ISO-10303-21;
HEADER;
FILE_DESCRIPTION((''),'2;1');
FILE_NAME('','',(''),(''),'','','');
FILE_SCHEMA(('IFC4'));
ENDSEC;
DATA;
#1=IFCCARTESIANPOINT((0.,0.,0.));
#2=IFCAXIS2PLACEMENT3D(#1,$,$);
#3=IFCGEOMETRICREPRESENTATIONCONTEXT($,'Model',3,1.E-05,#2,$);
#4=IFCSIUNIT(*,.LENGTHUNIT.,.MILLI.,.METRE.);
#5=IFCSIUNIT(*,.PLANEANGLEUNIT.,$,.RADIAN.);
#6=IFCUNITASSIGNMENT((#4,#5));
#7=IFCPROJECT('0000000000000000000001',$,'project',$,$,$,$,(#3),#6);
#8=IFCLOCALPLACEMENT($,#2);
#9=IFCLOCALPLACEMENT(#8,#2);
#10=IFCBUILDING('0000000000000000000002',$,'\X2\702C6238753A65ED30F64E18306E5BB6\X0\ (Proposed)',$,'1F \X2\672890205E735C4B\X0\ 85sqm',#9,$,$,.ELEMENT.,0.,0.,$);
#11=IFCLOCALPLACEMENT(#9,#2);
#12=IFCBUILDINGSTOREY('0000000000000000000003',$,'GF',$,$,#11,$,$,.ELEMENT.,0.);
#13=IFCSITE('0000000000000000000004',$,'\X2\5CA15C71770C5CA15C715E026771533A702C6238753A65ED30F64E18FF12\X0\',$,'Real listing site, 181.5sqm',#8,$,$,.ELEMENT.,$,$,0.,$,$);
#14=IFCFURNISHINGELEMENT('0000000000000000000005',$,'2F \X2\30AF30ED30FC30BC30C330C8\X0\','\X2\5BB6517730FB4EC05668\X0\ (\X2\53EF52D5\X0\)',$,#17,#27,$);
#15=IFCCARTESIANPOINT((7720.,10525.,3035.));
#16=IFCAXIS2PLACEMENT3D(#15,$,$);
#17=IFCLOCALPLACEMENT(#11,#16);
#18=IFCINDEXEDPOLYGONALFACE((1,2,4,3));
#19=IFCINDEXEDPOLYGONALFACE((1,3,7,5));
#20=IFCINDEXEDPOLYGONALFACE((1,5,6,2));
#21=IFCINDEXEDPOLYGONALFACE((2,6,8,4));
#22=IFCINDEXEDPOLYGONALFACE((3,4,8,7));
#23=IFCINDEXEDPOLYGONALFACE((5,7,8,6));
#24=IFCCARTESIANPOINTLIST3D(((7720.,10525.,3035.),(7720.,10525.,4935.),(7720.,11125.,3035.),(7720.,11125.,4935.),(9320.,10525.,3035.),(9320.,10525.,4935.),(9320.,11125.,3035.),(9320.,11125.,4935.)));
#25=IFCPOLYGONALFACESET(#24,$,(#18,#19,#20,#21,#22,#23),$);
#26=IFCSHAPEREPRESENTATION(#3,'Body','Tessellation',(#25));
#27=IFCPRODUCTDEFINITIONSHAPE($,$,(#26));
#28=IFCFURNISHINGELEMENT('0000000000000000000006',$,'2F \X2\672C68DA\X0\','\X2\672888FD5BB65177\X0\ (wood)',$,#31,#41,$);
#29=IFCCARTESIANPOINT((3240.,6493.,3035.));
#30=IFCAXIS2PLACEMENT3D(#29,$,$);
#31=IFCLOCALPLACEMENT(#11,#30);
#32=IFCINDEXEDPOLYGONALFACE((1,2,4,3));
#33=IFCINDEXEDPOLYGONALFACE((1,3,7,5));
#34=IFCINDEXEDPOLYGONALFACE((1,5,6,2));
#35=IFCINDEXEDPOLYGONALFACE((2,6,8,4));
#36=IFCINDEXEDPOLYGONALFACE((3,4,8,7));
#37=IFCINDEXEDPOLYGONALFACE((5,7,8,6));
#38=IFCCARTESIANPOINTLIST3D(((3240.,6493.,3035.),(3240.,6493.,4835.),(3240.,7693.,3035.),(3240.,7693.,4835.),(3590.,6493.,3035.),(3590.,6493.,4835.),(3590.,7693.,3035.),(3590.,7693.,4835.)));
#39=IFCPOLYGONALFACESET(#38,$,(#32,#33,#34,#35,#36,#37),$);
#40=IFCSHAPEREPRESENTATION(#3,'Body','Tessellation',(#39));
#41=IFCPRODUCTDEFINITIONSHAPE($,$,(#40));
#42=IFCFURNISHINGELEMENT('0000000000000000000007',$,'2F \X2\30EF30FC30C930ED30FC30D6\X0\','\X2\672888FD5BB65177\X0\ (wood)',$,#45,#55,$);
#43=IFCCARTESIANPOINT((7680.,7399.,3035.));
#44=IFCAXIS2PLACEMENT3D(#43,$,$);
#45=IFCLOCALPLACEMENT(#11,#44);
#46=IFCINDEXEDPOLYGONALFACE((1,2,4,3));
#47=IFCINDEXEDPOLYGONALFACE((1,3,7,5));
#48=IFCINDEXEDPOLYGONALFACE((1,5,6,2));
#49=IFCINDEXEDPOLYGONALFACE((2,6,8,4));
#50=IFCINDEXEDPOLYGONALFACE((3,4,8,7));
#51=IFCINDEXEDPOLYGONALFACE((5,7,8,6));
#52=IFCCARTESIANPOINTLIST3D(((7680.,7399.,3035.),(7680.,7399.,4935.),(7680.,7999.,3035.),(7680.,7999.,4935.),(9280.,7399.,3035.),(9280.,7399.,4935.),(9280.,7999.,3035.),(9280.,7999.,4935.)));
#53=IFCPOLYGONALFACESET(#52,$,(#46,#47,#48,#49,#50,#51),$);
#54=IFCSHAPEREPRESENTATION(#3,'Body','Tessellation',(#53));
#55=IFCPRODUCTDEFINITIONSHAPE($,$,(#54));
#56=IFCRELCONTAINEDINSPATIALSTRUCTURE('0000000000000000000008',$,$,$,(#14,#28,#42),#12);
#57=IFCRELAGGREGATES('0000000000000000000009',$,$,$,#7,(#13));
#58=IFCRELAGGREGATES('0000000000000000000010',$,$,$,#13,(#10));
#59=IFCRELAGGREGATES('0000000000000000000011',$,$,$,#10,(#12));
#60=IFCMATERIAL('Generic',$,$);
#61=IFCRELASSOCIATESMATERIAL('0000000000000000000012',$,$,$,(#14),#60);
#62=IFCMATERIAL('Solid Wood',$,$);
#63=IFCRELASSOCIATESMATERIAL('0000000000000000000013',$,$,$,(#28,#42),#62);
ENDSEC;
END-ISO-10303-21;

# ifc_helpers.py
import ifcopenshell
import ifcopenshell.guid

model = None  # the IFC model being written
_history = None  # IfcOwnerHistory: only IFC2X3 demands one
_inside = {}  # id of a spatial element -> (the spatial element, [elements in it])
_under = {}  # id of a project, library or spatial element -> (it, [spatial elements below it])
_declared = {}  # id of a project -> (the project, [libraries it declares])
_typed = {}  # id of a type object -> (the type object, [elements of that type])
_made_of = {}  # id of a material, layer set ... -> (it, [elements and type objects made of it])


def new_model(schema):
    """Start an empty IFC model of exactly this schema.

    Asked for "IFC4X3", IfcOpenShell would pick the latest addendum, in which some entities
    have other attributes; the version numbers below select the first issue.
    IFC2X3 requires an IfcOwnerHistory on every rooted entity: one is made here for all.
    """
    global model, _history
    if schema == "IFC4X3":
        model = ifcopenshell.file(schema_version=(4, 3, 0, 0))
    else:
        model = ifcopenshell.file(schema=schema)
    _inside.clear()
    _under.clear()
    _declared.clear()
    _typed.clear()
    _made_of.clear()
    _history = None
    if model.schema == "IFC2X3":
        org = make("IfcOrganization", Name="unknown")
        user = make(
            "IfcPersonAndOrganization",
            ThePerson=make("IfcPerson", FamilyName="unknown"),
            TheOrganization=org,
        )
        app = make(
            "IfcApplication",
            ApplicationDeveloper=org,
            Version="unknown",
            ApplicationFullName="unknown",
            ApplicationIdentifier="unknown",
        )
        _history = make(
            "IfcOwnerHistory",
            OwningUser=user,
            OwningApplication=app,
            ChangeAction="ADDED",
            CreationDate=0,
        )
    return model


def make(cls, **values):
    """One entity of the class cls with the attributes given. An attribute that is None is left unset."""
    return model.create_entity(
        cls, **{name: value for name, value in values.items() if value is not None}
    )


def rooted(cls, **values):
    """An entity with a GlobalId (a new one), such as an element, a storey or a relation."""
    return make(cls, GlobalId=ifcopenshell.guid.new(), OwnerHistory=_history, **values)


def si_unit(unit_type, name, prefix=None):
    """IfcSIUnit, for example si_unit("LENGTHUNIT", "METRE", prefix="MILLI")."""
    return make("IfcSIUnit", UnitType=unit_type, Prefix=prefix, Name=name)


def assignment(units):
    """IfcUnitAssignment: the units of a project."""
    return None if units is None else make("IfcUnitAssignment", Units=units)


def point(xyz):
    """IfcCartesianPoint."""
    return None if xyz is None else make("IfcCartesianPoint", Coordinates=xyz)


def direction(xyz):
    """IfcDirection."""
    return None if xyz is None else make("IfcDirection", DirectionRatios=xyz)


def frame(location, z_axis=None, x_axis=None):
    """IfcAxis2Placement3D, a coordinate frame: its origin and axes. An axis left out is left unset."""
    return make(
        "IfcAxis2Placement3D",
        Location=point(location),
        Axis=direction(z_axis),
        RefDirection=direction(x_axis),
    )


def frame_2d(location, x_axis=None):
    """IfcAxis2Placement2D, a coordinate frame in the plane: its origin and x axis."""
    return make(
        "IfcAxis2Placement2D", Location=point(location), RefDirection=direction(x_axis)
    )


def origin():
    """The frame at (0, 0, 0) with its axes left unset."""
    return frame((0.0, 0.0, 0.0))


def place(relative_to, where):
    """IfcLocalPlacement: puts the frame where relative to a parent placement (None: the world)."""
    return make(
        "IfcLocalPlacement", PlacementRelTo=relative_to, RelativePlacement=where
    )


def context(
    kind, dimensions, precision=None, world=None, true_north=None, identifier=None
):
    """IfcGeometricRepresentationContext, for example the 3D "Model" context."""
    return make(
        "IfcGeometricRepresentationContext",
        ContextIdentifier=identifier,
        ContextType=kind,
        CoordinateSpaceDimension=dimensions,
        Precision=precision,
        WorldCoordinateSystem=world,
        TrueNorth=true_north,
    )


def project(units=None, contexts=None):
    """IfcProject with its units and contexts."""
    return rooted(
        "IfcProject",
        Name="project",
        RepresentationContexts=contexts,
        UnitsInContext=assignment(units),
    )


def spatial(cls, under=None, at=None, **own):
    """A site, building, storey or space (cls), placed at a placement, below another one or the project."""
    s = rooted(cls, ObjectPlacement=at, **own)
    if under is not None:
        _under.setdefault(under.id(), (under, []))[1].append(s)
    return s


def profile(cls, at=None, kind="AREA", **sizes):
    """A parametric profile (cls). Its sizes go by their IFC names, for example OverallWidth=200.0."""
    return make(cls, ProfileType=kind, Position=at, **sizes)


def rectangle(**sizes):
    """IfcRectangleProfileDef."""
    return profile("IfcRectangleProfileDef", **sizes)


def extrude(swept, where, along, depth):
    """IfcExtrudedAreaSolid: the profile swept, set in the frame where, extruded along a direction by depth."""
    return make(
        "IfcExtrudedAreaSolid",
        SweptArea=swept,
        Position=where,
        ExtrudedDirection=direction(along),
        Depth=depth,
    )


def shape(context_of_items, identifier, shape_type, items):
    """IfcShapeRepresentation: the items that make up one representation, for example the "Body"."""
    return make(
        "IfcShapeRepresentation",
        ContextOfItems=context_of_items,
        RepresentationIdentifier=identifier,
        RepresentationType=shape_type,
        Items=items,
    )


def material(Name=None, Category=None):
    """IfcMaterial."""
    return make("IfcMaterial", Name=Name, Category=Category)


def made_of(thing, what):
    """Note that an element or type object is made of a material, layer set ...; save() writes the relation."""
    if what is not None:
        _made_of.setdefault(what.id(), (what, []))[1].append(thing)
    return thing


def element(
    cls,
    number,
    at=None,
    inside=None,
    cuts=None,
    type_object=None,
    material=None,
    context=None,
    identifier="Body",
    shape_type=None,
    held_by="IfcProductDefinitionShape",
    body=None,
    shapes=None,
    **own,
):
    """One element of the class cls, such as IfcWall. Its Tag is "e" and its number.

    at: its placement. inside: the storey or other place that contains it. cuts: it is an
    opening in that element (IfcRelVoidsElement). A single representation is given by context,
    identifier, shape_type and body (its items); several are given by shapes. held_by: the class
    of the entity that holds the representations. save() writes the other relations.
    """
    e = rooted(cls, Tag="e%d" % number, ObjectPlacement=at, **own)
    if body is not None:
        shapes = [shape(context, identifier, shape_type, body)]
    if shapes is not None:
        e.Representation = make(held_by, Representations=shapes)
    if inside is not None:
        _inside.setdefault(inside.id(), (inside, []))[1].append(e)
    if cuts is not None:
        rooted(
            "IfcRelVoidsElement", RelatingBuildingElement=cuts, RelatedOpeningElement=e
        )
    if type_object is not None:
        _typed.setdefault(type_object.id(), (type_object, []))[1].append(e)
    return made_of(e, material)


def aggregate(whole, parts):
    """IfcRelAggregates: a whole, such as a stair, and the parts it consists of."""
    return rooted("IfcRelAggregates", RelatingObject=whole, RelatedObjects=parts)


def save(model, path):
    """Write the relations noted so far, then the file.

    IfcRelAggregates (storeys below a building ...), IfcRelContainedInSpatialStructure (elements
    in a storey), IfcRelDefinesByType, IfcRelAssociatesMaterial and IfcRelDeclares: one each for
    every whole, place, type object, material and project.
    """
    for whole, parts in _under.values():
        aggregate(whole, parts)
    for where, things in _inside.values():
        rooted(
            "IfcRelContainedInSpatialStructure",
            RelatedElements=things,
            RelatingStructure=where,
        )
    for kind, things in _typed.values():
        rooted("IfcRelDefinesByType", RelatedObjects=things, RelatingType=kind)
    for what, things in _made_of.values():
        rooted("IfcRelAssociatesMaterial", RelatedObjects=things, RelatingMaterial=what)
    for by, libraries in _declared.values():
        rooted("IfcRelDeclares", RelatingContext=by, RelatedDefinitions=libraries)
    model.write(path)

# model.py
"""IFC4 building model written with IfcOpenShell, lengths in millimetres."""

from ifc_helpers import new_model, si_unit, frame, frame_2d, origin, place, context, project, spatial, rectangle, extrude, material, element, save


model = new_model("IFC4")

# Units and contexts
model_context = context("Model", 3, precision=1e-05, world=origin())
ifc_project = project(units=[si_unit("LENGTHUNIT", "METRE", prefix="MILLI"), si_unit("PLANEANGLEUNIT", "RADIAN")], contexts=[model_context])

# Site, building, storey
site_placement = place(None, origin())
site = spatial("IfcSite", under=ifc_project, at=site_placement, Name="岡山県岡山市東区瀬戸町旭ヶ丘２", ObjectType="Real listing site, 181.5sqm", CompositionType="ELEMENT", RefElevation=0.0)
building_placement = place(site_placement, origin())
building = spatial("IfcBuilding", under=site, at=building_placement, Name="瀬戸町旭ヶ丘の家 (Proposed)", ObjectType="1F 木造平屋 85sqm", CompositionType="ELEMENT", ElevationOfRefHeight=0.0, ElevationOfTerrain=0.0)
storey_placement = place(building_placement, origin())
storey = spatial("IfcBuildingStorey", under=building, at=storey_placement, Name="GF", CompositionType="ELEMENT", Elevation=0.0)

# Shared definitions
ifc_material_1 = material(Name="Solid Wood")

# Shared definitions
ifc_material_2 = material(Name="Generic")

# Furnishing elements
furnishing_1_placement = place(storey_placement, frame((7720.0, 10525.0, 3035.0)))
element("IfcFurnishingElement", 1, at=furnishing_1_placement, inside=storey, material=ifc_material_2, Name="2F クローゼット", Description="家具・什器 (可動)", context=model_context, shape_type="SweptSolid", body=[
    extrude(rectangle(XDim=1600.0, YDim=600.0, at=frame_2d((800.0, 300.0))), frame((7720.0, 10525.0, 3035.0)), (0.0, 0.0, 1.0), 1900.0),
])
furnishing_2_placement = place(storey_placement, frame((3240.0, 6493.0, 3035.0)))
element("IfcFurnishingElement", 2, at=furnishing_2_placement, inside=storey, material=ifc_material_1, Name="2F 本棚", Description="木製家具 (wood)", context=model_context, shape_type="SweptSolid", body=[
    extrude(rectangle(XDim=350.0, YDim=1200.0, at=frame_2d((175.0, 600.0))), frame((3240.0, 6493.0, 3035.0)), (0.0, 0.0, 1.0), 1800.0),
])
furnishing_3_placement = place(storey_placement, frame((7680.0, 7399.0, 3035.0)))
element("IfcFurnishingElement", 3, at=furnishing_3_placement, inside=storey, material=ifc_material_1, Name="2F ワードローブ", Description="木製家具 (wood)", context=model_context, shape_type="SweptSolid", body=[
    extrude(rectangle(XDim=1600.0, YDim=600.0, at=frame_2d((800.0, 300.0))), frame((7680.0, 7399.0, 3035.0)), (0.0, 0.0, 1.0), 1900.0),
])

save(model, "model.ifc")
